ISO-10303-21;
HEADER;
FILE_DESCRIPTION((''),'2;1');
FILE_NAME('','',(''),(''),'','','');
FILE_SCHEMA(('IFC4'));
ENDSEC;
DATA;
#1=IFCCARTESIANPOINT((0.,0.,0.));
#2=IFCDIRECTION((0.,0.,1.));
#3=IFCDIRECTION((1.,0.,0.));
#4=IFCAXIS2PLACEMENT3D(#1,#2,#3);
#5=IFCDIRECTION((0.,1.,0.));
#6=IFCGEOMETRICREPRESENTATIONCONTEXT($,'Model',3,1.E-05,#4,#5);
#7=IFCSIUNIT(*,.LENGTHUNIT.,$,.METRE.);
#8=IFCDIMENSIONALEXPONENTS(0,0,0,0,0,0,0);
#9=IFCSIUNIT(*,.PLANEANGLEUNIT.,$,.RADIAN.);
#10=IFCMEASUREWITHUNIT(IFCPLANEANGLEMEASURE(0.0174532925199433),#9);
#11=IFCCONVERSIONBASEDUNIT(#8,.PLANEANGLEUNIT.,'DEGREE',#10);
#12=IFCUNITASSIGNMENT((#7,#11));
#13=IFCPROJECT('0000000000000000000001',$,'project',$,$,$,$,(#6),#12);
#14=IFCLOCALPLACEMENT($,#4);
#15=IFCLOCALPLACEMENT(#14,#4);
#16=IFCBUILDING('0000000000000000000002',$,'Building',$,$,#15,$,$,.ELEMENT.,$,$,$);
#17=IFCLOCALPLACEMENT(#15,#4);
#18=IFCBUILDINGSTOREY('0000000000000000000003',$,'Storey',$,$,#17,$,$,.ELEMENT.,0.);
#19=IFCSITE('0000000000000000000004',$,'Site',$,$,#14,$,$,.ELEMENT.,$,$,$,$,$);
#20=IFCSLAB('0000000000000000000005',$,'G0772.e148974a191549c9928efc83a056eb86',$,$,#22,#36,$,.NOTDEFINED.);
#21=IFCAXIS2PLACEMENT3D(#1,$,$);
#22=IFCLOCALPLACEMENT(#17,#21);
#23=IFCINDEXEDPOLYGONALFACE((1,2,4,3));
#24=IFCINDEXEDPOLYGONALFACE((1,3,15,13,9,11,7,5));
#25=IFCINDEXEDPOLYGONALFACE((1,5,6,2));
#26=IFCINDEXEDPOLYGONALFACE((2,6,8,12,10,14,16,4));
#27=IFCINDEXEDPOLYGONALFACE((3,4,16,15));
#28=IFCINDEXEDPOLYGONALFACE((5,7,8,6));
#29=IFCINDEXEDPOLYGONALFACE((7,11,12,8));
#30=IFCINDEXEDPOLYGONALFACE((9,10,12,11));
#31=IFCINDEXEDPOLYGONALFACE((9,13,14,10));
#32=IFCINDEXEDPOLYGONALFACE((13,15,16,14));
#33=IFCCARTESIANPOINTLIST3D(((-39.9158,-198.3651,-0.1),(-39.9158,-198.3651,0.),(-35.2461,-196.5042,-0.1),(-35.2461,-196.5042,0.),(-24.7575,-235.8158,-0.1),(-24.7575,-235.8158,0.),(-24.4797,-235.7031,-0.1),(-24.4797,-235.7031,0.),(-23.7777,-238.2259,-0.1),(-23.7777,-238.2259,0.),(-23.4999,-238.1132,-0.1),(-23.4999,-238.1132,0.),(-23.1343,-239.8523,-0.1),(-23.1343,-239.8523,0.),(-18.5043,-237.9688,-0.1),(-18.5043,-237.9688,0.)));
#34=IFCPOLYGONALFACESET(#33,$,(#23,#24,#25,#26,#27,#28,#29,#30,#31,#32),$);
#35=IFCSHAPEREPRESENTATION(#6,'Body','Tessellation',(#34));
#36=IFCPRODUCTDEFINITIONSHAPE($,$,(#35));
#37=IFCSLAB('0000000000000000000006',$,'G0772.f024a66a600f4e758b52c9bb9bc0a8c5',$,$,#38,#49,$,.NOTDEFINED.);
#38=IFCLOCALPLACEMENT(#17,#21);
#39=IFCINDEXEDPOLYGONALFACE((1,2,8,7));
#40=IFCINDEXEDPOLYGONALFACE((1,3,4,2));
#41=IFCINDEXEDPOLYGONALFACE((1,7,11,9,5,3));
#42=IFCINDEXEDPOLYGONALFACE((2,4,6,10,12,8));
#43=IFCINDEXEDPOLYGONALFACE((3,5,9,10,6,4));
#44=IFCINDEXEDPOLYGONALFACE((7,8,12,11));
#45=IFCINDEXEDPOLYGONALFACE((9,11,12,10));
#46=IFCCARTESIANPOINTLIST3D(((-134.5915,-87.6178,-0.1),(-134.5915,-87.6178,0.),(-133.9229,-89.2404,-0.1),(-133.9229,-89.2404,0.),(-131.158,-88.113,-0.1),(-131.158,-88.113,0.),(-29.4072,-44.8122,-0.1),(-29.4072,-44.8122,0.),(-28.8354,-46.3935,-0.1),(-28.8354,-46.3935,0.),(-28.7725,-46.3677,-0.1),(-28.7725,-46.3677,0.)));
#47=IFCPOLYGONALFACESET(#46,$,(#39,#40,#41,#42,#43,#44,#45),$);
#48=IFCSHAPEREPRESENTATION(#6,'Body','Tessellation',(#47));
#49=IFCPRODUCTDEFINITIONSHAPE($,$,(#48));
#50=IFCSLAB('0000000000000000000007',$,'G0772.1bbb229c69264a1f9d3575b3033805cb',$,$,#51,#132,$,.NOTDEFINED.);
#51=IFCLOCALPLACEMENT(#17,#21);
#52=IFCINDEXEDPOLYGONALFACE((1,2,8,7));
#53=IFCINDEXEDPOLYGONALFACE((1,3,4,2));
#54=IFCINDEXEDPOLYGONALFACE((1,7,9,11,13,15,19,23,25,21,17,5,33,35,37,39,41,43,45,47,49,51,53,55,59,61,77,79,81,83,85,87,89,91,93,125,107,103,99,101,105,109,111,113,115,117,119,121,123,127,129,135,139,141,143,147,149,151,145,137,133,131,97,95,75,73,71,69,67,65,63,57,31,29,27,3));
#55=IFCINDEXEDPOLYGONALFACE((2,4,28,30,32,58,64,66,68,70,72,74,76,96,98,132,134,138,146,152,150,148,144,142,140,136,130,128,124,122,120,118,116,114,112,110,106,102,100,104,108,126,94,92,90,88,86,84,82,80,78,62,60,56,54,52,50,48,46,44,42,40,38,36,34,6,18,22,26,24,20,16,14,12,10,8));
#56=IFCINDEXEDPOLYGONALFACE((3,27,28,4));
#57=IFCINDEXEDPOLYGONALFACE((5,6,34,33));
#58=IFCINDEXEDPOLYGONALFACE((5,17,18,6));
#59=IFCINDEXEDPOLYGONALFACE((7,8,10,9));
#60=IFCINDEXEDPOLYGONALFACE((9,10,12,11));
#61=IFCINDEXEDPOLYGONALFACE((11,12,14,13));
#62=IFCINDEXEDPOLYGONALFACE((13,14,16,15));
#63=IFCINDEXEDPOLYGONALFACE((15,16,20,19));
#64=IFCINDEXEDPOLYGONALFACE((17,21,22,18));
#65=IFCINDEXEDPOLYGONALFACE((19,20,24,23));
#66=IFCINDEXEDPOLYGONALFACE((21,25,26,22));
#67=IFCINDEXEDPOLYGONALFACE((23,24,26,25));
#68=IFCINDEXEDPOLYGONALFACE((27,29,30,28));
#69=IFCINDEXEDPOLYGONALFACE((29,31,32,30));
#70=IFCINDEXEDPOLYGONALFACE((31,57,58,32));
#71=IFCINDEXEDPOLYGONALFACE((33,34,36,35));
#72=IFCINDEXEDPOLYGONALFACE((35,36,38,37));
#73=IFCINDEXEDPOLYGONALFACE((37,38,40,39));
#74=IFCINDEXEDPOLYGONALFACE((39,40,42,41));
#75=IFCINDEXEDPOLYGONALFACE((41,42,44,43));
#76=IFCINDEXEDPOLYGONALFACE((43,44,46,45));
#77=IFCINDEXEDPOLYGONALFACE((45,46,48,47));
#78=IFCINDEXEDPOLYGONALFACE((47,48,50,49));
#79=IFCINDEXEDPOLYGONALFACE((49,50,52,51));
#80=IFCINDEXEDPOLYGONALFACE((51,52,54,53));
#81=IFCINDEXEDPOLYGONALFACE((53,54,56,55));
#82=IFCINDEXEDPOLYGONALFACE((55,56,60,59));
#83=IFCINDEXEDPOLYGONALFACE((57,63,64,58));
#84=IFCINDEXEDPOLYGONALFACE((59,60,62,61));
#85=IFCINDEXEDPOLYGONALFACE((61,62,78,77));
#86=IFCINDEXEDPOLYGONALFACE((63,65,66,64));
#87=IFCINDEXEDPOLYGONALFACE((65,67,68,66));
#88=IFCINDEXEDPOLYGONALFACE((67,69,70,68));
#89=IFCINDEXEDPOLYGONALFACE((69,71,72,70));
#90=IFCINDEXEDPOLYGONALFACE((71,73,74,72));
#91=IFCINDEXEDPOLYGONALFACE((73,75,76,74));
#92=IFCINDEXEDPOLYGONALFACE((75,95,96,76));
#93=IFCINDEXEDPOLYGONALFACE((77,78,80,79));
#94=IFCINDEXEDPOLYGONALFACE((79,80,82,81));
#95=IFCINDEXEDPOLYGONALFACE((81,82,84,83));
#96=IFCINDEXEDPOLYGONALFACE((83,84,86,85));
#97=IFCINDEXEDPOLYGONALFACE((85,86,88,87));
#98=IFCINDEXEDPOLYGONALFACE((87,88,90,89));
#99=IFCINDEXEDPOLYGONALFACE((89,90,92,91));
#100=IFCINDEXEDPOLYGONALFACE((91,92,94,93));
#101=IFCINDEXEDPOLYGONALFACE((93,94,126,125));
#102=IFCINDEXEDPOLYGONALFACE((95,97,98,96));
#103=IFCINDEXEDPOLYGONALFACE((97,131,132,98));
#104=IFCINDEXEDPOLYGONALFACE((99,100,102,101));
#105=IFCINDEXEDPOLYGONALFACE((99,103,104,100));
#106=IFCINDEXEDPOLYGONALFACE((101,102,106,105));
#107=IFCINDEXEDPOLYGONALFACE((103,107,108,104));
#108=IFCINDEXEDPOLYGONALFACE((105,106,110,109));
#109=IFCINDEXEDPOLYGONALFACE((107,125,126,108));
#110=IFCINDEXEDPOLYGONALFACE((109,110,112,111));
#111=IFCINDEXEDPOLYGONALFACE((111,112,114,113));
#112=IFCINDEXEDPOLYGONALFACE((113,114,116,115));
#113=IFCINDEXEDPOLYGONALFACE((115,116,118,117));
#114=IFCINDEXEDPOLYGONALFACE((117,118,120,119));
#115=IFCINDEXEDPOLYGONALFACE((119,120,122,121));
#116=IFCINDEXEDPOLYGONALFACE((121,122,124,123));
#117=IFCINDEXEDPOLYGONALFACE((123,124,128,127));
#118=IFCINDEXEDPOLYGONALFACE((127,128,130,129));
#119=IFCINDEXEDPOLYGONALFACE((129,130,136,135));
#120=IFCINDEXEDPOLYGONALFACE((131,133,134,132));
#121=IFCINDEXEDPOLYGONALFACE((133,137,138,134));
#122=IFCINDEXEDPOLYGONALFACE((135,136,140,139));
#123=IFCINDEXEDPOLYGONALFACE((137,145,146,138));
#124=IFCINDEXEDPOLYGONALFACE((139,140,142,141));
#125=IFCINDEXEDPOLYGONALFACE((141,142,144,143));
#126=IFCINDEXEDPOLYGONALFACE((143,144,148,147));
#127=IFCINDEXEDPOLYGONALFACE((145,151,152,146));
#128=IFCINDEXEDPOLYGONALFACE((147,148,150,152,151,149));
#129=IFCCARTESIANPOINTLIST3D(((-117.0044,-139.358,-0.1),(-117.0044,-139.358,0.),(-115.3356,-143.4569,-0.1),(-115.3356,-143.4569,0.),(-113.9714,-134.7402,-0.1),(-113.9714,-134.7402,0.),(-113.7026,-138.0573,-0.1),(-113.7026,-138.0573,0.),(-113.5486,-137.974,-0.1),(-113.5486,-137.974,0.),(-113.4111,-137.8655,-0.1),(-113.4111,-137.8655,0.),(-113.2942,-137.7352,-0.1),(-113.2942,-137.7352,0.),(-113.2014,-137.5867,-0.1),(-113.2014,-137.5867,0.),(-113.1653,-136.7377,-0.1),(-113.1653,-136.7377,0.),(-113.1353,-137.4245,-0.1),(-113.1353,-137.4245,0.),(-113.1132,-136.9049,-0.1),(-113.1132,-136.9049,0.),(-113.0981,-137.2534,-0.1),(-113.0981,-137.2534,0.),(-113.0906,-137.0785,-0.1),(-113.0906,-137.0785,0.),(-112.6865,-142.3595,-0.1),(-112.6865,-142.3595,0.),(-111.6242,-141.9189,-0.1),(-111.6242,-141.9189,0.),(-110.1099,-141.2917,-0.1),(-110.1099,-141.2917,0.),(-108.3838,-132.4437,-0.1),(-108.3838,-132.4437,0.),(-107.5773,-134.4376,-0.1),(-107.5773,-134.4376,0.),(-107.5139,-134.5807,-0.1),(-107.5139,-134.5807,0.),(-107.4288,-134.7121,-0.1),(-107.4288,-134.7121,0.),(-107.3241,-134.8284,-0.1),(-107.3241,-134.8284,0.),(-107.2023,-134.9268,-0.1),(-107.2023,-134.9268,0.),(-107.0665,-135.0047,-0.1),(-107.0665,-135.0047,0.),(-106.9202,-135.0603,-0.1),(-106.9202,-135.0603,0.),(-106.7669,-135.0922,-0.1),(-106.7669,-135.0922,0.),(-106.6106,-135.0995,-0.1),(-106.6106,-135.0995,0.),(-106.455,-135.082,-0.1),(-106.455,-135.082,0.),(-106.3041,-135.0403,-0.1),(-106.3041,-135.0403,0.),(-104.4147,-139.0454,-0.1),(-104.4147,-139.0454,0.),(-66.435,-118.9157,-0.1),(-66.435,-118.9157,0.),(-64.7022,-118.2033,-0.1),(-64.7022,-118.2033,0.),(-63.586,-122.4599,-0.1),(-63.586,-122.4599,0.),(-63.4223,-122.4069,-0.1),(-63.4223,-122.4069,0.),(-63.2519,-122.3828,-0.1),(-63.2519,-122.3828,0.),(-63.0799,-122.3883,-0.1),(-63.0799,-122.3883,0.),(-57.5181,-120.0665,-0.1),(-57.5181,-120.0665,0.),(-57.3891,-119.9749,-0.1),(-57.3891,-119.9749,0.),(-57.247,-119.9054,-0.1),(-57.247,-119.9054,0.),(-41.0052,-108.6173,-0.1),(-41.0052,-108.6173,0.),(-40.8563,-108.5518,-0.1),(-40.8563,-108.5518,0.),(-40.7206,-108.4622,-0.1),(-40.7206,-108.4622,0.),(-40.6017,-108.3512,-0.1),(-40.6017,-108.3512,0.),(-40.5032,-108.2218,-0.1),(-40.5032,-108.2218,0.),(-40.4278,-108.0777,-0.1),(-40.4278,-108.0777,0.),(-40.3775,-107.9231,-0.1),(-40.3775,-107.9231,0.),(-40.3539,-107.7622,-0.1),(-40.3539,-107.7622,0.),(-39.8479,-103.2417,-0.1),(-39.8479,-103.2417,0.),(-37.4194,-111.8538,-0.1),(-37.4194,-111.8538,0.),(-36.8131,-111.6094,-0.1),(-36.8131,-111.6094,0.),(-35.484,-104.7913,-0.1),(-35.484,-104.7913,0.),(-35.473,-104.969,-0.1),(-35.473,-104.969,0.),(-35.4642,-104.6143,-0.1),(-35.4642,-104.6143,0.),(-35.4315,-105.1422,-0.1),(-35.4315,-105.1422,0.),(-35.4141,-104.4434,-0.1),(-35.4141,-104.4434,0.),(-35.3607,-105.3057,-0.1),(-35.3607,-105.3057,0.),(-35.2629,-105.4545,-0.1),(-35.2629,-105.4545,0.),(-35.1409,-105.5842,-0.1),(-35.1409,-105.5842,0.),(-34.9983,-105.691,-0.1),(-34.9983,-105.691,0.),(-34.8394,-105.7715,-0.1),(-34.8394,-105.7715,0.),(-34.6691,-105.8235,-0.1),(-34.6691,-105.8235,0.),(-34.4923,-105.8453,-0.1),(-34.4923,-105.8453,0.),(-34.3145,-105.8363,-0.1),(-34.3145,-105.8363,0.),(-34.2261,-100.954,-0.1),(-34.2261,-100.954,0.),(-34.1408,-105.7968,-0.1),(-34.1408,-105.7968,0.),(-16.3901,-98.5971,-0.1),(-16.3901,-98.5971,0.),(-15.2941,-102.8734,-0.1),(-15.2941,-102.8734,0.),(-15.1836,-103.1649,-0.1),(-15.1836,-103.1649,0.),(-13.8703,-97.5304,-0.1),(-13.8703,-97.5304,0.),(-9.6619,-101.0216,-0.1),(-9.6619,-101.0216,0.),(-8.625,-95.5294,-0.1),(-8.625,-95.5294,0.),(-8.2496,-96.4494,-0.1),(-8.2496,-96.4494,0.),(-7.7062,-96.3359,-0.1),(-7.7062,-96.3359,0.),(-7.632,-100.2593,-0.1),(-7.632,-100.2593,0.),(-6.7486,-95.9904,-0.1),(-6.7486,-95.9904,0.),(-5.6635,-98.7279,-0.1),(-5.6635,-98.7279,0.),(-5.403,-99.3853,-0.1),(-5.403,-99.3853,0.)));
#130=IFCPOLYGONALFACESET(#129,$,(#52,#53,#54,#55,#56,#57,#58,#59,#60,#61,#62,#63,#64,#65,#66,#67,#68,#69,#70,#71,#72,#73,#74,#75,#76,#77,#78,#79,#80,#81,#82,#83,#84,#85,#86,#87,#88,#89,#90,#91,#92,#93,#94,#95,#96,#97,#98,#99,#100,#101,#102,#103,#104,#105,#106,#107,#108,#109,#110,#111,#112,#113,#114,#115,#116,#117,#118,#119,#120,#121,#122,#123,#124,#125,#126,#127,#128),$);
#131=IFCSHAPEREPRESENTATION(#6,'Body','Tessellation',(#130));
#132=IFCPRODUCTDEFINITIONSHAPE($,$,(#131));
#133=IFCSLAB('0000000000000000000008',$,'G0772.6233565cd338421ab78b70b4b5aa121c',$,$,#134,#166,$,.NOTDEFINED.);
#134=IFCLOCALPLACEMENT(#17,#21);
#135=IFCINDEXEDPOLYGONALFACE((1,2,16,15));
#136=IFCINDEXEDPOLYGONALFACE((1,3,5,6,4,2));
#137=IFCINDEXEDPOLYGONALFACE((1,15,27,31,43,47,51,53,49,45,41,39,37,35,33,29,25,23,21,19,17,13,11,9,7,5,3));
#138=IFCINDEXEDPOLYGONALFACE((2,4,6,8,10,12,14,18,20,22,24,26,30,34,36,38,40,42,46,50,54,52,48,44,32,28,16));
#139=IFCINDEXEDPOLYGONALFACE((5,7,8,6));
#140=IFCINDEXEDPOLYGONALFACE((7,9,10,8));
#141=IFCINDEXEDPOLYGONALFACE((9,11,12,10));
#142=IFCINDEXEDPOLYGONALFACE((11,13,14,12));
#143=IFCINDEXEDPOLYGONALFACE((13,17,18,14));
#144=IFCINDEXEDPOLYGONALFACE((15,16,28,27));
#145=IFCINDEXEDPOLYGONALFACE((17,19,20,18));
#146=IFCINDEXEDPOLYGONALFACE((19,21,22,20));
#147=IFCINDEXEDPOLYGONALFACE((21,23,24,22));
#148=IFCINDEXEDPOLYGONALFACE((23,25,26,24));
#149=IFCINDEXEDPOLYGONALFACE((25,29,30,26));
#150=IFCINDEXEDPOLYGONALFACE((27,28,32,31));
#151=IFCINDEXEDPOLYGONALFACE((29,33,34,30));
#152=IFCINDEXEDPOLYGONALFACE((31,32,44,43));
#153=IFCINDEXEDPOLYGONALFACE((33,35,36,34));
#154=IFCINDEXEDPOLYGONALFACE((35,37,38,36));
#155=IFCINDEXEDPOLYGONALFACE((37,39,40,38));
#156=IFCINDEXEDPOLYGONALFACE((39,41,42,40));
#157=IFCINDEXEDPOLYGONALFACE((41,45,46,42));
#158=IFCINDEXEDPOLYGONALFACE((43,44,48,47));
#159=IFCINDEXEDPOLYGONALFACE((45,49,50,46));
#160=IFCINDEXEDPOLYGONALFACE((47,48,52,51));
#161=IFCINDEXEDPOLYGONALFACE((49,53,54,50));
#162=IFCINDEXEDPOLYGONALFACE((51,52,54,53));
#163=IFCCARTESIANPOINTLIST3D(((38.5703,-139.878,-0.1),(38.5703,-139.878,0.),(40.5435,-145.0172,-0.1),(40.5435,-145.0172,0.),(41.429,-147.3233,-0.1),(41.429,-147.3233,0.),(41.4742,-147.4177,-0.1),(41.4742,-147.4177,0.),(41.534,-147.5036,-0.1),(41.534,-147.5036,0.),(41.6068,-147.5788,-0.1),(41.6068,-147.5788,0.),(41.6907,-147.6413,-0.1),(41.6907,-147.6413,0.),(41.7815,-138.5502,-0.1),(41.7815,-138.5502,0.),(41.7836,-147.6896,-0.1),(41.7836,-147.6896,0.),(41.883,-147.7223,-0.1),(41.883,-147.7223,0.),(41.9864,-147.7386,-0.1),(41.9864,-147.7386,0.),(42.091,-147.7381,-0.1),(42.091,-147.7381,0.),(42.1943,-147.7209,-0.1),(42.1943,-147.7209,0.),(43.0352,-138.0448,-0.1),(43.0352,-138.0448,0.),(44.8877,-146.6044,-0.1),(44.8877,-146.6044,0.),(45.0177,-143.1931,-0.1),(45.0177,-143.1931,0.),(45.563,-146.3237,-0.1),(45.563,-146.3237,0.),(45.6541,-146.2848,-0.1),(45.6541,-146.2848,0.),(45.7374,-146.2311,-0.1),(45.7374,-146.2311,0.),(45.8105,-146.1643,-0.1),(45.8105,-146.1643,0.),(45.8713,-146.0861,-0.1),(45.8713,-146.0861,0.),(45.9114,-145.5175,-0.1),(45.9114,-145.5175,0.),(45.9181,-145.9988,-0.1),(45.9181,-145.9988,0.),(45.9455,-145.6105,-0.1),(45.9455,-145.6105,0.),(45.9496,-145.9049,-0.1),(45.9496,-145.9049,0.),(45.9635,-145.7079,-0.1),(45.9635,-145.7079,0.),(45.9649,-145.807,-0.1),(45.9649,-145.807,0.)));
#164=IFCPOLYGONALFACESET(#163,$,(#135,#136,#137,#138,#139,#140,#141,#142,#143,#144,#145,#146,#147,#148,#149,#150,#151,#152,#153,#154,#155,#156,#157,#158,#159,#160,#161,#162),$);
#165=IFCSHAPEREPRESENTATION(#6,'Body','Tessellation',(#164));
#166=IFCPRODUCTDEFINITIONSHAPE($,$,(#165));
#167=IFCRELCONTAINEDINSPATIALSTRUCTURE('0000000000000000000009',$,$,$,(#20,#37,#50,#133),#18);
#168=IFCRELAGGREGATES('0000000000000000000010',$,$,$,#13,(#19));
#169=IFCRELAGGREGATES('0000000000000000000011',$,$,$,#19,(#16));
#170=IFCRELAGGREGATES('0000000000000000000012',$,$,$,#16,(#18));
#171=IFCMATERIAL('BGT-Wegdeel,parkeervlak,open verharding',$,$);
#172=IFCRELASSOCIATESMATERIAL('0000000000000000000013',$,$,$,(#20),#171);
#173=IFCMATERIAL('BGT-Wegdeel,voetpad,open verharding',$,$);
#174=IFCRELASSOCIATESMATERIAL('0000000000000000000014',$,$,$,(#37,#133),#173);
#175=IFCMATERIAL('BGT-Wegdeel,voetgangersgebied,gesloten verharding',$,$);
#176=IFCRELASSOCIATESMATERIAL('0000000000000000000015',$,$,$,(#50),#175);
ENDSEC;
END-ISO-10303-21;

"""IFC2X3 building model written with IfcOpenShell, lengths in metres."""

from ifc_helpers import new_model, entity, si_unit, converted_unit, direction, frame, origin_with_axes, place, context, project, spatial, polyline, outline, extrude, material, element, save


model = new_model("IFC2X3")

# Units and contexts
model_context = context("Model", 3, precision=1e-05, world=origin_with_axes(), true_north=direction((0.0, 1.0, 0.0)))
ifc_project = project(units=[si_unit("LENGTHUNIT", "METRE"), converted_unit("PLANEANGLEUNIT", "DEGREE", entity("IfcPlaneAngleMeasure", 0.0174532925199433), si_unit("PLANEANGLEUNIT", "RADIAN"), dimensions=[0, 0, 0, 0, 0, 0, 0])], contexts=[model_context])

# Site, building, storey
site_placement = place(None, origin_with_axes())
site = spatial("IfcSite", under=ifc_project, at=site_placement, Name="Site", CompositionType="ELEMENT")
building_placement = place(site_placement, origin_with_axes())
building = spatial("IfcBuilding", under=site, at=building_placement, Name="Building", CompositionType="ELEMENT")
storey_placement = place(building_placement, origin_with_axes())
storey = spatial("IfcBuildingStorey", under=building, at=storey_placement, Name="Storey", CompositionType="ELEMENT", Elevation=0.0)

# Slabs
ifc_material_1 = material(Name="BGT-Wegdeel,parkeervlak,open verharding")
slab_1_placement = place(storey_placement, frame((0.0, 0.0, -0.1), z_axis=(0.0, 0.0, 1.0), x_axis=(1.0, 0.0, 0.0)))
element("IfcSlab", 1, at=slab_1_placement, inside=storey, material=ifc_material_1, Name="G0772.e148974a191549c9928efc83a056eb86", PredefinedType="NOTDEFINED", context=model_context, shape_type="SweptSolid", body=[
    extrude(outline(polyline([(-39.9158, -198.3651), (-35.2461, -196.5042), (-18.5043, -237.9688), (-23.1343, -239.8523), (-23.7777, -238.2259), (-23.4999, -238.1132), (-24.4797, -235.7031), (-24.7575, -235.8158), (-39.9158, -198.3651)])), origin_with_axes(), (0.0, 0.0, 1.0), 0.1),
])
ifc_material_2 = material(Name="BGT-Wegdeel,voetpad,open verharding")
slab_2_placement = place(storey_placement, frame((0.0, 0.0, -0.1), z_axis=(0.0, 0.0, 1.0), x_axis=(1.0, 0.0, 0.0)))
element("IfcSlab", 2, at=slab_2_placement, inside=storey, material=ifc_material_2, Name="G0772.f024a66a600f4e758b52c9bb9bc0a8c5", PredefinedType="NOTDEFINED", context=model_context, shape_type="SweptSolid", body=[
    extrude(outline(polyline([(-29.4072, -44.8122), (-28.7725, -46.3677), (-28.8354, -46.3935), (-131.158, -88.113), (-133.9229, -89.2404), (-134.5915, -87.6178), (-29.4072, -44.8122)])), origin_with_axes(), (0.0, 0.0, 1.0), 0.1),
])
ifc_material_3 = material(Name="BGT-Wegdeel,voetgangersgebied,gesloten verharding")
slab_3_placement = place(storey_placement, frame((0.0, 0.0, -0.1), z_axis=(0.0, 0.0, 1.0), x_axis=(1.0, 0.0, 0.0)))
element("IfcSlab", 3, at=slab_3_placement, inside=storey, material=ifc_material_3, Name="G0772.1bbb229c69264a1f9d3575b3033805cb", PredefinedType="NOTDEFINED", context=model_context, shape_type="SweptSolid", body=[
    extrude(outline(polyline([(-41.0052, -108.6173), (-40.8563, -108.5518), (-40.7206, -108.4622), (-40.6017, -108.3512), (-40.5032, -108.2218), (-40.4278, -108.0777), (-40.3775, -107.9231), (-40.3539, -107.7622), (-39.8479, -103.2417), (-34.2261, -100.954), (-35.4141, -104.4434), (-35.4642, -104.6143), (-35.484, -104.7913), (-35.473, -104.969), (-35.4315, -105.1422), (-35.3607, -105.3057), (-35.2629, -105.4545), (-35.1409, -105.5842), (-34.9983, -105.691), (-34.8394, -105.7715), (-34.6691, -105.8235), (-34.4923, -105.8453), (-34.3145, -105.8363), (-34.1408, -105.7968), (-16.3901, -98.5971), (-13.8703, -97.5304), (-8.625, -95.5294), (-8.2496, -96.4494), (-7.7062, -96.3359), (-6.7486, -95.9904), (-5.6635, -98.7279), (-5.403, -99.3853), (-7.632, -100.2593), (-9.6619, -101.0216), (-15.1836, -103.1649), (-15.2941, -102.8734), (-36.8131, -111.6094), (-37.4194, -111.8538), (-57.247, -119.9054), (-57.3891, -119.9749), (-57.5181, -120.0665), (-63.0799, -122.3883), (-63.2519, -122.3828), (-63.4223, -122.4069), (-63.586, -122.4599), (-104.4147, -139.0454), (-110.1099, -141.2917), (-111.6242, -141.9189), (-112.6865, -142.3595), (-115.3356, -143.4569), (-117.0044, -139.358), (-113.7026, -138.0573), (-113.5486, -137.974), (-113.4111, -137.8655), (-113.2942, -137.7352), (-113.2014, -137.5867), (-113.1353, -137.4245), (-113.0981, -137.2534), (-113.0906, -137.0785), (-113.1132, -136.9049), (-113.1653, -136.7377), (-113.9714, -134.7402), (-108.3838, -132.4437), (-107.5773, -134.4376), (-107.5139, -134.5807), (-107.4288, -134.7121), (-107.3241, -134.8284), (-107.2023, -134.9268), (-107.0665, -135.0047), (-106.9202, -135.0603), (-106.7669, -135.0922), (-106.6106, -135.0995), (-106.455, -135.082), (-106.3041, -135.0403), (-66.435, -118.9157), (-64.7022, -118.2033), (-41.0052, -108.6173)])), origin_with_axes(), (0.0, 0.0, 1.0), 0.1),
])
slab_4_placement = place(storey_placement, frame((0.0, 0.0, -0.1), z_axis=(0.0, 0.0, 1.0), x_axis=(1.0, 0.0, 0.0)))
element("IfcSlab", 4, at=slab_4_placement, inside=storey, material=ifc_material_2, Name="G0772.6233565cd338421ab78b70b4b5aa121c", PredefinedType="NOTDEFINED", context=model_context, shape_type="SweptSolid", body=[
    extrude(outline(polyline([(45.0177, -143.1931), (45.9114, -145.5175), (45.9455, -145.6105), (45.9635, -145.7079), (45.9649, -145.807), (45.9496, -145.9049), (45.9181, -145.9988), (45.8713, -146.0861), (45.8105, -146.1643), (45.7374, -146.2311), (45.6541, -146.2848), (45.563, -146.3237), (44.8877, -146.6044), (42.1943, -147.7209), (42.091, -147.7381), (41.9864, -147.7386), (41.883, -147.7223), (41.7836, -147.6896), (41.6907, -147.6413), (41.6068, -147.5788), (41.534, -147.5036), (41.4742, -147.4177), (41.429, -147.3233), (40.5435, -145.0172), (38.5703, -139.878), (41.7815, -138.5502), (43.0352, -138.0448), (45.0177, -143.1931)])), origin_with_axes(), (0.0, 0.0, 1.0), 0.1),
])

save(model, "model.ifc")
